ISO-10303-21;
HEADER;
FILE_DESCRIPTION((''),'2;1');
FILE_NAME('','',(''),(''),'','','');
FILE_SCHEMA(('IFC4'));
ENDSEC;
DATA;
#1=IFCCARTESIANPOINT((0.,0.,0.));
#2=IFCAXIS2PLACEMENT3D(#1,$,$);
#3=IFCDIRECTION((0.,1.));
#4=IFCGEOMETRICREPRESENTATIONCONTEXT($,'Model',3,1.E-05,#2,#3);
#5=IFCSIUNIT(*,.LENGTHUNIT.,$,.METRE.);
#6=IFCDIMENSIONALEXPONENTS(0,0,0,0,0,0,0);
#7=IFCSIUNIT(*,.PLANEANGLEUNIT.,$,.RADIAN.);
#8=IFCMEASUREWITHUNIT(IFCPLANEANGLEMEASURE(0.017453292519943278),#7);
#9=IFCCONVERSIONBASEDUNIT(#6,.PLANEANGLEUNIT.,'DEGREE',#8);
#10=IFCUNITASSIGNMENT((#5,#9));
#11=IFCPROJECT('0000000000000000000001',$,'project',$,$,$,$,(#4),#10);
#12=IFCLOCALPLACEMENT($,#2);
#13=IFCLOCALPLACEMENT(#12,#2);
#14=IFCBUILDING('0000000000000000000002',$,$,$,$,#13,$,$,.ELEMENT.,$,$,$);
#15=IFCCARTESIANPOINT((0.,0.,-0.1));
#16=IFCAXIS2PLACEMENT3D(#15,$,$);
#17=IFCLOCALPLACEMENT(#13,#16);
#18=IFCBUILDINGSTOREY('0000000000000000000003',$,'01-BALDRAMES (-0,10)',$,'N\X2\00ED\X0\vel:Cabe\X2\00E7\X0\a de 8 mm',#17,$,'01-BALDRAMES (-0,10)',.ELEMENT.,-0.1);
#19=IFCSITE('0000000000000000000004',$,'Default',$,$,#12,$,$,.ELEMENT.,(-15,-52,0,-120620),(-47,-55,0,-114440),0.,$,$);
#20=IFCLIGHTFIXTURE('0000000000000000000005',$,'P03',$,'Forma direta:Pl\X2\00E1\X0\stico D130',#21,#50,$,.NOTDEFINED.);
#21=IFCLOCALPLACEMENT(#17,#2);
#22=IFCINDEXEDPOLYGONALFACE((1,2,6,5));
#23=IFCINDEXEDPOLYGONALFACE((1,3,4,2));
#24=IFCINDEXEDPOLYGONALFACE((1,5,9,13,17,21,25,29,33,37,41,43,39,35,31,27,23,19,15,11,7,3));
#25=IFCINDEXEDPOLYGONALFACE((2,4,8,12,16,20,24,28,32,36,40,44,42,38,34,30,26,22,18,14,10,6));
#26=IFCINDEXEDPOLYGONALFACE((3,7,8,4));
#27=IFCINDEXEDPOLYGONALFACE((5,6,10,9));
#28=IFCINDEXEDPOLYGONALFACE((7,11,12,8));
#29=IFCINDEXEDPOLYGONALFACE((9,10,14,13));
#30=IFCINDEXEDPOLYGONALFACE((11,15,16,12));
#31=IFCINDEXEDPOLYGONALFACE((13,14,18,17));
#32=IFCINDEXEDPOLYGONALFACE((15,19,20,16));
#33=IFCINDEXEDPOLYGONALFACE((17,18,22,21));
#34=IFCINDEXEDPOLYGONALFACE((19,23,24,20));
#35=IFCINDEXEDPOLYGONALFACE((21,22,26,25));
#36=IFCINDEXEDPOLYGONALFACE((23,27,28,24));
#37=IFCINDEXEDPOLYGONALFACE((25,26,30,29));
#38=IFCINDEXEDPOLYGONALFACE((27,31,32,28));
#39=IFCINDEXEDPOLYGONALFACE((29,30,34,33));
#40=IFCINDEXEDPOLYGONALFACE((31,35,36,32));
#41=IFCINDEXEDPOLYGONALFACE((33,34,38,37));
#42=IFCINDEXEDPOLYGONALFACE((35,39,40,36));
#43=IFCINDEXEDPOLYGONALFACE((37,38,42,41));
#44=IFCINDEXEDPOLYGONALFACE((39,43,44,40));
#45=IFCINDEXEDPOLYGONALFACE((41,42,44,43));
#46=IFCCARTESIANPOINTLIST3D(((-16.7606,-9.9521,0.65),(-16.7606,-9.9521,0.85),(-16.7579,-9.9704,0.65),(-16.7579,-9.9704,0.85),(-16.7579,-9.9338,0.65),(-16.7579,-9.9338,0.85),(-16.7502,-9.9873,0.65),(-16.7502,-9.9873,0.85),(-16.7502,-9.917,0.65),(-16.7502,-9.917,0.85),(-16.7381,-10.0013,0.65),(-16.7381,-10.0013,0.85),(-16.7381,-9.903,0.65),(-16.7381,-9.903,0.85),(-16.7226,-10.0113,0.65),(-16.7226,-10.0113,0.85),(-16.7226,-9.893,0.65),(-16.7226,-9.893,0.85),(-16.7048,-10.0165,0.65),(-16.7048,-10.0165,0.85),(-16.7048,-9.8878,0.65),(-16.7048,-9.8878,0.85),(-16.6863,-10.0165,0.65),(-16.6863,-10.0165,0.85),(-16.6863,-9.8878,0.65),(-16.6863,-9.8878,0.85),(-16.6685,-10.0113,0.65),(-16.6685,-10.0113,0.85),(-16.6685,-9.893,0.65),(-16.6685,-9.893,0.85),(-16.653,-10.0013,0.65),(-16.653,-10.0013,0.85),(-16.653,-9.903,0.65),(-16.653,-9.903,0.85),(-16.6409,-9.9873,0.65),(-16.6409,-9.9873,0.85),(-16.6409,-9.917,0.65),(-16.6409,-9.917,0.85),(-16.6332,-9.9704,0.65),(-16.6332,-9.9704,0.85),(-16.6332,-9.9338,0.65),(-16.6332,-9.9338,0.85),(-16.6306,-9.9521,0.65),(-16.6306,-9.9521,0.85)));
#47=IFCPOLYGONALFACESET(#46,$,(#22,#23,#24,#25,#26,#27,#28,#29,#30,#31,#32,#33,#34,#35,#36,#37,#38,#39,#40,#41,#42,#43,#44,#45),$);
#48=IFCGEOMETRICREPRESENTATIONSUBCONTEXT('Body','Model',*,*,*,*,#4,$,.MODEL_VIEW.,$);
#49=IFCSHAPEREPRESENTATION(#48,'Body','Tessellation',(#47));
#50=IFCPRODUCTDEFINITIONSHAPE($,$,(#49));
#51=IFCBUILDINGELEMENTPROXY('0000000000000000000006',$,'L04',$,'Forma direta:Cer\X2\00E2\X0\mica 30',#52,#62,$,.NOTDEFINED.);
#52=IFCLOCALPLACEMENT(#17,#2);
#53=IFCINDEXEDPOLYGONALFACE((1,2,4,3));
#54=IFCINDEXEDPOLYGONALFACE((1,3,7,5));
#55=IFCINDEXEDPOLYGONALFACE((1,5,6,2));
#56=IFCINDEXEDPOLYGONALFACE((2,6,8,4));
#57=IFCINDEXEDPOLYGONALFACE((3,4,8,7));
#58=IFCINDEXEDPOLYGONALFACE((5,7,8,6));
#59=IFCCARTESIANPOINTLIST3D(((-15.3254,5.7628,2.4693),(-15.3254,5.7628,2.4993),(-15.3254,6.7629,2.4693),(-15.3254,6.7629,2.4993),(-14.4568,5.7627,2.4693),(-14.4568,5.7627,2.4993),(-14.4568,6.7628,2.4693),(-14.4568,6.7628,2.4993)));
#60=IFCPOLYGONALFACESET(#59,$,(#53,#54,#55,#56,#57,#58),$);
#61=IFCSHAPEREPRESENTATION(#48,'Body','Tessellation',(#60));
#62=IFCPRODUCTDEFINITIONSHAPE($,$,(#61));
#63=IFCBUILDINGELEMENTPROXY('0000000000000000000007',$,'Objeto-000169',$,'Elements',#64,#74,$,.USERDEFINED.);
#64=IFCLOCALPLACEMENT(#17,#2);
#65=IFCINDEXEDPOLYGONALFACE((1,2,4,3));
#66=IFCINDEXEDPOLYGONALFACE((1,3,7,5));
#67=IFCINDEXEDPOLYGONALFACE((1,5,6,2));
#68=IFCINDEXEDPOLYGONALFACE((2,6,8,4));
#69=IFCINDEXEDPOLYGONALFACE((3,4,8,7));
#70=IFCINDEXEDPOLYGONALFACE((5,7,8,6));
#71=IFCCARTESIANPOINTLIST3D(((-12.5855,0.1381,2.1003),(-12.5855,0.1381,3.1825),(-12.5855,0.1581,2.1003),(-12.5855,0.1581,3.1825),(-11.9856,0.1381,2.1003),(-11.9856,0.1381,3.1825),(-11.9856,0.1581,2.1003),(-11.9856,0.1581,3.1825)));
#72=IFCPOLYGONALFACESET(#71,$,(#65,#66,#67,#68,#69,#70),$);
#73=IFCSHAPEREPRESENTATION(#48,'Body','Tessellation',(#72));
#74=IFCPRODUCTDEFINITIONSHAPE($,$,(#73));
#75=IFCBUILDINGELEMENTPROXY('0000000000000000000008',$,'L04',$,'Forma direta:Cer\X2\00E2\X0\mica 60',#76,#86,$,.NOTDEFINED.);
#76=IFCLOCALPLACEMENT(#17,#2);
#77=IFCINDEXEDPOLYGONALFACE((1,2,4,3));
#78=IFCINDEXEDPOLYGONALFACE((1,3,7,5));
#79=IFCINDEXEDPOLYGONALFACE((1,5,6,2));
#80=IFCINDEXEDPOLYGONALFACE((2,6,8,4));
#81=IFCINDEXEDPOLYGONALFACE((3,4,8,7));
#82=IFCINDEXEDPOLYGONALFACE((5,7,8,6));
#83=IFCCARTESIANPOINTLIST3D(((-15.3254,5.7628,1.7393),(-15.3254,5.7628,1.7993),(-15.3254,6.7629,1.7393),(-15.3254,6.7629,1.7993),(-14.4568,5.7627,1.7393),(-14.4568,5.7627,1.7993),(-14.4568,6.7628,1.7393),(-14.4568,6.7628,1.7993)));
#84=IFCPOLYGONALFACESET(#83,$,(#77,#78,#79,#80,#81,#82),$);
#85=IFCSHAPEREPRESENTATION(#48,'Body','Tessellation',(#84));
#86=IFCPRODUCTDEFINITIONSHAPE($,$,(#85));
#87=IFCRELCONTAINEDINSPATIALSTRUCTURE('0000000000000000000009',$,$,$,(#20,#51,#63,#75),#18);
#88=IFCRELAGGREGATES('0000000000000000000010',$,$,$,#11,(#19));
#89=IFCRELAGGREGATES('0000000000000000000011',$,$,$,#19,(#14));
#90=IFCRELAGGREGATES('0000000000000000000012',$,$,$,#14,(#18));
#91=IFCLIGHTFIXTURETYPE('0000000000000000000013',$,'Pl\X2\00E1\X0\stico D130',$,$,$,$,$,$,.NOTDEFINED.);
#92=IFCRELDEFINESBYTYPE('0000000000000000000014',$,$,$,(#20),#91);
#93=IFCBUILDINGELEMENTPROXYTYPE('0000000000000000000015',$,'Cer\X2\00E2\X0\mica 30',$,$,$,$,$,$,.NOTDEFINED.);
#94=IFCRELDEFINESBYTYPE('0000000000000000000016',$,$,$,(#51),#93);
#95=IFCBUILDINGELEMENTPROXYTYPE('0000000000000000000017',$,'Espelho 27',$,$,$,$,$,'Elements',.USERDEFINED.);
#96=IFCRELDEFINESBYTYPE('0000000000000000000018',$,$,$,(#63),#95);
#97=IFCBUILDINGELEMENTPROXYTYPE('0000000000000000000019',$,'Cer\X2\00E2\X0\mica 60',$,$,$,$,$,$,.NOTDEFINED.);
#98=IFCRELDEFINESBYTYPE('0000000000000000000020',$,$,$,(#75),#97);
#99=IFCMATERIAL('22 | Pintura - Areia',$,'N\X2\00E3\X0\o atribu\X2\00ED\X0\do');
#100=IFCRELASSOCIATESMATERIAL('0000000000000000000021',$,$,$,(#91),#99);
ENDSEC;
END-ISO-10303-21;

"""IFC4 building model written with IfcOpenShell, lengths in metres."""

from ifc_helpers import new_model, entity, si_unit, converted_unit, direction, frame, origin, place, context, subcontext, project, spatial, arc, indexed_curve, outline, extrude, material, type_object, element, save


model = new_model("IFC4")

# Units and contexts
model_context = context("Model", 3, precision=1e-05, world=origin(), true_north=direction((0.0, 1.0)))
body_context = subcontext(model_context, "Body", "Model", "MODEL_VIEW")
ifc_project = project(units=[si_unit("LENGTHUNIT", "METRE"), converted_unit("PLANEANGLEUNIT", "DEGREE", entity("IfcPlaneAngleMeasure", 0.017453292519943278), si_unit("PLANEANGLEUNIT", "RADIAN"), dimensions=[0, 0, 0, 0, 0, 0, 0])], contexts=[model_context])

# Site, building, storey
site_placement = place(None, origin())
site = spatial("IfcSite", under=ifc_project, at=site_placement, Name="Default", CompositionType="ELEMENT", RefLatitude=(-15, -52, 0, -120620), RefLongitude=(-47, -55, 0, -114440), RefElevation=0.0)
building_placement = place(site_placement, origin())
building = spatial("IfcBuilding", under=site, at=building_placement, CompositionType="ELEMENT")
storey_placement = place(building_placement, frame((0.0, 0.0, -0.1)))
storey = spatial("IfcBuildingStorey", under=building, at=storey_placement, Name="01-BALDRAMES (-0,10)", ObjectType="Nível:Cabeça de 8 mm", LongName="01-BALDRAMES (-0,10)", CompositionType="ELEMENT", Elevation=-0.1)

# Shared definitions
ifc_material_1 = material(Name="22 | Pintura - Areia", Category="Não atribuído")

# Light fixture
light_fixture_type_1 = type_object("IfcLightFixtureType", Name="Plástico D130", PredefinedType="NOTDEFINED", material=ifc_material_1)
light_fixture_1_placement = place(storey_placement, origin())
element("IfcLightFixture", 1, at=light_fixture_1_placement, inside=storey, type_object=light_fixture_type_1, Name="P03", ObjectType="Forma direta:Plástico D130", PredefinedType="NOTDEFINED", context=body_context, shape_type="SweptSolid", body=[
    extrude(outline(indexed_curve([(0.065, 0.0), (0.0, 0.065), (-0.065, 0.0), (0.0, -0.065)], segments=[arc(1, 2, 3), arc(3, 4, 1)], self_intersect=False)), frame((-16.6956, -9.9521, 0.65)), (0.0, 0.0, 1.0), 0.2),
])

# Building element proxies
building_element_proxy_type_1 = type_object("IfcBuildingElementProxyType", Name="Cerâmica 30", PredefinedType="NOTDEFINED")
proxy_1_placement = place(storey_placement, origin())
element("IfcBuildingElementProxy", 2, at=proxy_1_placement, inside=storey, type_object=building_element_proxy_type_1, Name="L04", ObjectType="Forma direta:Cerâmica 30", PredefinedType="NOTDEFINED", context=body_context, shape_type="SweptSolid", body=[
    extrude(outline(indexed_curve([(-0.5, -0.4343), (0.5, -0.4343), (0.5, 0.4343), (-0.5, 0.4343), (-0.5, -0.4343)], self_intersect=False)), frame((-14.8911, 6.2628, 2.4693), z_axis=(0.0, 0.0, 1.0), x_axis=(0.000013, 1.0, 0.0)), (0.0, 0.0, 1.0), 0.03),
])
building_element_proxy_type_2 = type_object("IfcBuildingElementProxyType", Name="Espelho 27", ElementType="Elements", PredefinedType="USERDEFINED")
proxy_2_placement = place(storey_placement, origin())
element("IfcBuildingElementProxy", 3, at=proxy_2_placement, inside=storey, type_object=building_element_proxy_type_2, Name="Objeto-000169", ObjectType="Elements", PredefinedType="USERDEFINED", context=body_context, shape_type="SweptSolid", body=[
    extrude(outline(indexed_curve([(-0.01, -0.2999), (0.01, -0.2999), (0.01, 0.2999), (-0.01, 0.2999), (-0.01, -0.2999)], self_intersect=False)), frame((-12.2855, 0.1481, 2.1003), z_axis=(0.0, 0.0, 1.0), x_axis=(0.000009, 1.0, 0.0)), (0.0, 0.0, 1.0), 1.0822),
])
building_element_proxy_type_3 = type_object("IfcBuildingElementProxyType", Name="Cerâmica 60", PredefinedType="NOTDEFINED")
proxy_3_placement = place(storey_placement, origin())
element("IfcBuildingElementProxy", 4, at=proxy_3_placement, inside=storey, type_object=building_element_proxy_type_3, Name="L04", ObjectType="Forma direta:Cerâmica 60", PredefinedType="NOTDEFINED", context=body_context, shape_type="SweptSolid", body=[
    extrude(outline(indexed_curve([(-0.5, -0.4343), (0.5, -0.4343), (0.5, 0.4343), (-0.5, 0.4343), (-0.5, -0.4343)], self_intersect=False)), frame((-14.8911, 6.2628, 1.7393), z_axis=(0.0, 0.0, 1.0), x_axis=(0.000013, 1.0, 0.0)), (0.0, 0.0, 1.0), 0.06),
])

save(model, "model.ifc")
